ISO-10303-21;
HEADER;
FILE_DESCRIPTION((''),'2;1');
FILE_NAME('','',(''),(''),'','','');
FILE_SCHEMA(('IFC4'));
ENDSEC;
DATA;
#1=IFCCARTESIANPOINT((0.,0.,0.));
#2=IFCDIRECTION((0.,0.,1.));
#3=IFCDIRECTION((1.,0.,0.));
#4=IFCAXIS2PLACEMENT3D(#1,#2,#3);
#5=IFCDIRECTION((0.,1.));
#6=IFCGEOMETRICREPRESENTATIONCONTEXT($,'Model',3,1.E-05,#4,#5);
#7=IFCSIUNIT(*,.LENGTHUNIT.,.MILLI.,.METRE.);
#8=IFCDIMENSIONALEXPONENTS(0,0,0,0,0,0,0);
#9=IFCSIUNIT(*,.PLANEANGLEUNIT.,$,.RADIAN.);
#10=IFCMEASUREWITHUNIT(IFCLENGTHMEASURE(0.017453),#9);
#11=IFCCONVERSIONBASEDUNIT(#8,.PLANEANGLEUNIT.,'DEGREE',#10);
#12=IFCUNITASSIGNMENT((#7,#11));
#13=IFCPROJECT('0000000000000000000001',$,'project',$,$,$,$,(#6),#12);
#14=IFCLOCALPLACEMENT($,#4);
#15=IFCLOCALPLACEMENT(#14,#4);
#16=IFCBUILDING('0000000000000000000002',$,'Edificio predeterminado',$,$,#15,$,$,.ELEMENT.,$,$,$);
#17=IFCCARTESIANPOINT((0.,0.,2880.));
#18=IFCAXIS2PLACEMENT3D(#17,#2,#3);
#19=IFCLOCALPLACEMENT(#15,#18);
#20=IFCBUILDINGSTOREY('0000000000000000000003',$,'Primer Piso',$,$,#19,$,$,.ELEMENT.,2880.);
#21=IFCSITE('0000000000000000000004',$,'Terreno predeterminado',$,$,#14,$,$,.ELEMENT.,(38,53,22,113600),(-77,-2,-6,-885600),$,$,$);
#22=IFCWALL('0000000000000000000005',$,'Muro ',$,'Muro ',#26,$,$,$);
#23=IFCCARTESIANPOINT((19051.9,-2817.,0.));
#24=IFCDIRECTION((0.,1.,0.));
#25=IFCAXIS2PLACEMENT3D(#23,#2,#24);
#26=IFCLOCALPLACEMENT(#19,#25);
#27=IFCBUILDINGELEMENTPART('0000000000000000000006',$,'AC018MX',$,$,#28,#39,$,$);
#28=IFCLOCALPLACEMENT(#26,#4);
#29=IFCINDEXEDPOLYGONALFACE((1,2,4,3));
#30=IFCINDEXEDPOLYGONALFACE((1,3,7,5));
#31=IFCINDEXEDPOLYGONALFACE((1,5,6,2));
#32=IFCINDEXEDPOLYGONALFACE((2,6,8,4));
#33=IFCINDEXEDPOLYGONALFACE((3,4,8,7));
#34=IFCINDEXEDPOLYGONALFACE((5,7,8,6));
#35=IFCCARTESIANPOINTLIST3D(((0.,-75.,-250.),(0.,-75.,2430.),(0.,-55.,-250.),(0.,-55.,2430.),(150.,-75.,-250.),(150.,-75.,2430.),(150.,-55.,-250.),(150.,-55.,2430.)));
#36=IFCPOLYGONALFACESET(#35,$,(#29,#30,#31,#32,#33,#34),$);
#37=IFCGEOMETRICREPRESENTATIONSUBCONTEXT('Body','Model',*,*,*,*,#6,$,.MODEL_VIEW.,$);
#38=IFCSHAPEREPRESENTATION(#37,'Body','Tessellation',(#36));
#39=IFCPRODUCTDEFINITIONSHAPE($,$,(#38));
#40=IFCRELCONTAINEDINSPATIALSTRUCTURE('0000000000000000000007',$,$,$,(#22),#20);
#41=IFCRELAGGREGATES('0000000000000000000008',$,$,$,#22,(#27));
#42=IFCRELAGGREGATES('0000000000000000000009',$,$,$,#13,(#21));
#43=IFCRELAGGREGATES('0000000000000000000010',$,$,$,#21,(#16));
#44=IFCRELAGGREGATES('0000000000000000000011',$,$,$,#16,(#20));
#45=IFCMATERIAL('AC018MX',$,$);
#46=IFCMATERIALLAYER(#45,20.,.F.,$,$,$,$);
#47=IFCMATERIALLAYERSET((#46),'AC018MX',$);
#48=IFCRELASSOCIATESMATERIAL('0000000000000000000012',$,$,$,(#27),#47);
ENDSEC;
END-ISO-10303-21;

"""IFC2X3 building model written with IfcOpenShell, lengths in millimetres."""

from ifc_helpers import new_model, entity, si_unit, converted_unit, direction, frame, origin_with_axes, place, context, subcontext, project, spatial, polyline, outline, extrude, clip, bounded_halfspace, material, layer, layer_set, layer_usage, element, aggregate, save


model = new_model("IFC2X3")

# Units and contexts
model_context = context("Model", 3, precision=1e-05, world=origin_with_axes(), true_north=direction((0.0, 1.0)))
body_context = subcontext(model_context, "Body", "Model", "MODEL_VIEW")
ifc_project = project(units=[si_unit("LENGTHUNIT", "METRE", prefix="MILLI"), converted_unit("PLANEANGLEUNIT", "DEGREE", entity("IfcLengthMeasure", 0.017453), si_unit("PLANEANGLEUNIT", "RADIAN"), dimensions=[0, 0, 0, 0, 0, 0, 0])], contexts=[model_context])

# Site, building, storey
site_placement = place(None, origin_with_axes())
site = spatial("IfcSite", under=ifc_project, at=site_placement, Name="Terreno predeterminado", CompositionType="ELEMENT", RefLatitude=(38, 53, 22, 113600), RefLongitude=(-77, -2, -6, -885600))
building_placement = place(site_placement, origin_with_axes())
building = spatial("IfcBuilding", under=site, at=building_placement, Name="Edificio predeterminado", CompositionType="ELEMENT")
storey_placement = place(building_placement, frame((0.0, 0.0, 2880.0), z_axis=(0.0, 0.0, 1.0), x_axis=(1.0, 0.0, 0.0)))
storey = spatial("IfcBuildingStorey", under=building, at=storey_placement, Name="Primer Piso", CompositionType="ELEMENT", Elevation=2880.0)

# Wall, building element part
wall_1_placement = place(storey_placement, frame((19051.9, -2817.0, 0.0), z_axis=(0.0, 0.0, 1.0), x_axis=(0.0, 1.0, 0.0)))
wall_1 = element("IfcWall", 1, at=wall_1_placement, inside=storey, Name="Muro ", ObjectType="Muro ")
ifc_material_1 = material(Name="AC018MX")
ifc_layer_1 = layer(ifc_material_1, 20.0, ventilated=False)
ifc_layer_set_1 = layer_set([ifc_layer_1], Name="AC018MX")
ifc_layer_usage_1 = layer_usage(ifc_layer_set_1, "AXIS2", "NEGATIVE", 55.0)
building_element_part_1_placement = place(wall_1_placement, origin_with_axes())
building_element_part_1 = element("IfcBuildingElementPart", 2, at=building_element_part_1_placement, material=ifc_layer_usage_1, Name="AC018MX", context=body_context, shape_type="Clipping", body=[
    clip(clip(extrude(outline(polyline([(150.0, -55.0), (150.0, -75.0), (0.0, -75.0), (0.0, -55.0), (150.0, -55.0)])), frame((0.0, 0.0, -250.0), z_axis=(0.0, 0.0, 1.0), x_axis=(1.0, 0.0, 0.0)), (0.0, 0.0, 1.0), 2680.0), bounded_halfspace(frame((0.0, 0.0, -250.0), z_axis=(0.0, 0.0, 1.0), x_axis=(1.0, 0.0, 0.0)), True, origin_with_axes(), polyline([(-150.0, -150.0), (375.0, -150.0), (375.0, 150.0), (-150.0, 150.0), (-150.0, -150.0)]))), bounded_halfspace(frame((0.0, 0.0, 2430.0), z_axis=(0.0, 0.0, 1.0), x_axis=(1.0, 0.0, 0.0)), False, origin_with_axes(), polyline([(-150.0, -150.0), (375.0, -150.0), (375.0, 150.0), (-150.0, 150.0), (-150.0, -150.0)]))),
])
aggregate(wall_1, [building_element_part_1])

save(model, "model.ifc")
